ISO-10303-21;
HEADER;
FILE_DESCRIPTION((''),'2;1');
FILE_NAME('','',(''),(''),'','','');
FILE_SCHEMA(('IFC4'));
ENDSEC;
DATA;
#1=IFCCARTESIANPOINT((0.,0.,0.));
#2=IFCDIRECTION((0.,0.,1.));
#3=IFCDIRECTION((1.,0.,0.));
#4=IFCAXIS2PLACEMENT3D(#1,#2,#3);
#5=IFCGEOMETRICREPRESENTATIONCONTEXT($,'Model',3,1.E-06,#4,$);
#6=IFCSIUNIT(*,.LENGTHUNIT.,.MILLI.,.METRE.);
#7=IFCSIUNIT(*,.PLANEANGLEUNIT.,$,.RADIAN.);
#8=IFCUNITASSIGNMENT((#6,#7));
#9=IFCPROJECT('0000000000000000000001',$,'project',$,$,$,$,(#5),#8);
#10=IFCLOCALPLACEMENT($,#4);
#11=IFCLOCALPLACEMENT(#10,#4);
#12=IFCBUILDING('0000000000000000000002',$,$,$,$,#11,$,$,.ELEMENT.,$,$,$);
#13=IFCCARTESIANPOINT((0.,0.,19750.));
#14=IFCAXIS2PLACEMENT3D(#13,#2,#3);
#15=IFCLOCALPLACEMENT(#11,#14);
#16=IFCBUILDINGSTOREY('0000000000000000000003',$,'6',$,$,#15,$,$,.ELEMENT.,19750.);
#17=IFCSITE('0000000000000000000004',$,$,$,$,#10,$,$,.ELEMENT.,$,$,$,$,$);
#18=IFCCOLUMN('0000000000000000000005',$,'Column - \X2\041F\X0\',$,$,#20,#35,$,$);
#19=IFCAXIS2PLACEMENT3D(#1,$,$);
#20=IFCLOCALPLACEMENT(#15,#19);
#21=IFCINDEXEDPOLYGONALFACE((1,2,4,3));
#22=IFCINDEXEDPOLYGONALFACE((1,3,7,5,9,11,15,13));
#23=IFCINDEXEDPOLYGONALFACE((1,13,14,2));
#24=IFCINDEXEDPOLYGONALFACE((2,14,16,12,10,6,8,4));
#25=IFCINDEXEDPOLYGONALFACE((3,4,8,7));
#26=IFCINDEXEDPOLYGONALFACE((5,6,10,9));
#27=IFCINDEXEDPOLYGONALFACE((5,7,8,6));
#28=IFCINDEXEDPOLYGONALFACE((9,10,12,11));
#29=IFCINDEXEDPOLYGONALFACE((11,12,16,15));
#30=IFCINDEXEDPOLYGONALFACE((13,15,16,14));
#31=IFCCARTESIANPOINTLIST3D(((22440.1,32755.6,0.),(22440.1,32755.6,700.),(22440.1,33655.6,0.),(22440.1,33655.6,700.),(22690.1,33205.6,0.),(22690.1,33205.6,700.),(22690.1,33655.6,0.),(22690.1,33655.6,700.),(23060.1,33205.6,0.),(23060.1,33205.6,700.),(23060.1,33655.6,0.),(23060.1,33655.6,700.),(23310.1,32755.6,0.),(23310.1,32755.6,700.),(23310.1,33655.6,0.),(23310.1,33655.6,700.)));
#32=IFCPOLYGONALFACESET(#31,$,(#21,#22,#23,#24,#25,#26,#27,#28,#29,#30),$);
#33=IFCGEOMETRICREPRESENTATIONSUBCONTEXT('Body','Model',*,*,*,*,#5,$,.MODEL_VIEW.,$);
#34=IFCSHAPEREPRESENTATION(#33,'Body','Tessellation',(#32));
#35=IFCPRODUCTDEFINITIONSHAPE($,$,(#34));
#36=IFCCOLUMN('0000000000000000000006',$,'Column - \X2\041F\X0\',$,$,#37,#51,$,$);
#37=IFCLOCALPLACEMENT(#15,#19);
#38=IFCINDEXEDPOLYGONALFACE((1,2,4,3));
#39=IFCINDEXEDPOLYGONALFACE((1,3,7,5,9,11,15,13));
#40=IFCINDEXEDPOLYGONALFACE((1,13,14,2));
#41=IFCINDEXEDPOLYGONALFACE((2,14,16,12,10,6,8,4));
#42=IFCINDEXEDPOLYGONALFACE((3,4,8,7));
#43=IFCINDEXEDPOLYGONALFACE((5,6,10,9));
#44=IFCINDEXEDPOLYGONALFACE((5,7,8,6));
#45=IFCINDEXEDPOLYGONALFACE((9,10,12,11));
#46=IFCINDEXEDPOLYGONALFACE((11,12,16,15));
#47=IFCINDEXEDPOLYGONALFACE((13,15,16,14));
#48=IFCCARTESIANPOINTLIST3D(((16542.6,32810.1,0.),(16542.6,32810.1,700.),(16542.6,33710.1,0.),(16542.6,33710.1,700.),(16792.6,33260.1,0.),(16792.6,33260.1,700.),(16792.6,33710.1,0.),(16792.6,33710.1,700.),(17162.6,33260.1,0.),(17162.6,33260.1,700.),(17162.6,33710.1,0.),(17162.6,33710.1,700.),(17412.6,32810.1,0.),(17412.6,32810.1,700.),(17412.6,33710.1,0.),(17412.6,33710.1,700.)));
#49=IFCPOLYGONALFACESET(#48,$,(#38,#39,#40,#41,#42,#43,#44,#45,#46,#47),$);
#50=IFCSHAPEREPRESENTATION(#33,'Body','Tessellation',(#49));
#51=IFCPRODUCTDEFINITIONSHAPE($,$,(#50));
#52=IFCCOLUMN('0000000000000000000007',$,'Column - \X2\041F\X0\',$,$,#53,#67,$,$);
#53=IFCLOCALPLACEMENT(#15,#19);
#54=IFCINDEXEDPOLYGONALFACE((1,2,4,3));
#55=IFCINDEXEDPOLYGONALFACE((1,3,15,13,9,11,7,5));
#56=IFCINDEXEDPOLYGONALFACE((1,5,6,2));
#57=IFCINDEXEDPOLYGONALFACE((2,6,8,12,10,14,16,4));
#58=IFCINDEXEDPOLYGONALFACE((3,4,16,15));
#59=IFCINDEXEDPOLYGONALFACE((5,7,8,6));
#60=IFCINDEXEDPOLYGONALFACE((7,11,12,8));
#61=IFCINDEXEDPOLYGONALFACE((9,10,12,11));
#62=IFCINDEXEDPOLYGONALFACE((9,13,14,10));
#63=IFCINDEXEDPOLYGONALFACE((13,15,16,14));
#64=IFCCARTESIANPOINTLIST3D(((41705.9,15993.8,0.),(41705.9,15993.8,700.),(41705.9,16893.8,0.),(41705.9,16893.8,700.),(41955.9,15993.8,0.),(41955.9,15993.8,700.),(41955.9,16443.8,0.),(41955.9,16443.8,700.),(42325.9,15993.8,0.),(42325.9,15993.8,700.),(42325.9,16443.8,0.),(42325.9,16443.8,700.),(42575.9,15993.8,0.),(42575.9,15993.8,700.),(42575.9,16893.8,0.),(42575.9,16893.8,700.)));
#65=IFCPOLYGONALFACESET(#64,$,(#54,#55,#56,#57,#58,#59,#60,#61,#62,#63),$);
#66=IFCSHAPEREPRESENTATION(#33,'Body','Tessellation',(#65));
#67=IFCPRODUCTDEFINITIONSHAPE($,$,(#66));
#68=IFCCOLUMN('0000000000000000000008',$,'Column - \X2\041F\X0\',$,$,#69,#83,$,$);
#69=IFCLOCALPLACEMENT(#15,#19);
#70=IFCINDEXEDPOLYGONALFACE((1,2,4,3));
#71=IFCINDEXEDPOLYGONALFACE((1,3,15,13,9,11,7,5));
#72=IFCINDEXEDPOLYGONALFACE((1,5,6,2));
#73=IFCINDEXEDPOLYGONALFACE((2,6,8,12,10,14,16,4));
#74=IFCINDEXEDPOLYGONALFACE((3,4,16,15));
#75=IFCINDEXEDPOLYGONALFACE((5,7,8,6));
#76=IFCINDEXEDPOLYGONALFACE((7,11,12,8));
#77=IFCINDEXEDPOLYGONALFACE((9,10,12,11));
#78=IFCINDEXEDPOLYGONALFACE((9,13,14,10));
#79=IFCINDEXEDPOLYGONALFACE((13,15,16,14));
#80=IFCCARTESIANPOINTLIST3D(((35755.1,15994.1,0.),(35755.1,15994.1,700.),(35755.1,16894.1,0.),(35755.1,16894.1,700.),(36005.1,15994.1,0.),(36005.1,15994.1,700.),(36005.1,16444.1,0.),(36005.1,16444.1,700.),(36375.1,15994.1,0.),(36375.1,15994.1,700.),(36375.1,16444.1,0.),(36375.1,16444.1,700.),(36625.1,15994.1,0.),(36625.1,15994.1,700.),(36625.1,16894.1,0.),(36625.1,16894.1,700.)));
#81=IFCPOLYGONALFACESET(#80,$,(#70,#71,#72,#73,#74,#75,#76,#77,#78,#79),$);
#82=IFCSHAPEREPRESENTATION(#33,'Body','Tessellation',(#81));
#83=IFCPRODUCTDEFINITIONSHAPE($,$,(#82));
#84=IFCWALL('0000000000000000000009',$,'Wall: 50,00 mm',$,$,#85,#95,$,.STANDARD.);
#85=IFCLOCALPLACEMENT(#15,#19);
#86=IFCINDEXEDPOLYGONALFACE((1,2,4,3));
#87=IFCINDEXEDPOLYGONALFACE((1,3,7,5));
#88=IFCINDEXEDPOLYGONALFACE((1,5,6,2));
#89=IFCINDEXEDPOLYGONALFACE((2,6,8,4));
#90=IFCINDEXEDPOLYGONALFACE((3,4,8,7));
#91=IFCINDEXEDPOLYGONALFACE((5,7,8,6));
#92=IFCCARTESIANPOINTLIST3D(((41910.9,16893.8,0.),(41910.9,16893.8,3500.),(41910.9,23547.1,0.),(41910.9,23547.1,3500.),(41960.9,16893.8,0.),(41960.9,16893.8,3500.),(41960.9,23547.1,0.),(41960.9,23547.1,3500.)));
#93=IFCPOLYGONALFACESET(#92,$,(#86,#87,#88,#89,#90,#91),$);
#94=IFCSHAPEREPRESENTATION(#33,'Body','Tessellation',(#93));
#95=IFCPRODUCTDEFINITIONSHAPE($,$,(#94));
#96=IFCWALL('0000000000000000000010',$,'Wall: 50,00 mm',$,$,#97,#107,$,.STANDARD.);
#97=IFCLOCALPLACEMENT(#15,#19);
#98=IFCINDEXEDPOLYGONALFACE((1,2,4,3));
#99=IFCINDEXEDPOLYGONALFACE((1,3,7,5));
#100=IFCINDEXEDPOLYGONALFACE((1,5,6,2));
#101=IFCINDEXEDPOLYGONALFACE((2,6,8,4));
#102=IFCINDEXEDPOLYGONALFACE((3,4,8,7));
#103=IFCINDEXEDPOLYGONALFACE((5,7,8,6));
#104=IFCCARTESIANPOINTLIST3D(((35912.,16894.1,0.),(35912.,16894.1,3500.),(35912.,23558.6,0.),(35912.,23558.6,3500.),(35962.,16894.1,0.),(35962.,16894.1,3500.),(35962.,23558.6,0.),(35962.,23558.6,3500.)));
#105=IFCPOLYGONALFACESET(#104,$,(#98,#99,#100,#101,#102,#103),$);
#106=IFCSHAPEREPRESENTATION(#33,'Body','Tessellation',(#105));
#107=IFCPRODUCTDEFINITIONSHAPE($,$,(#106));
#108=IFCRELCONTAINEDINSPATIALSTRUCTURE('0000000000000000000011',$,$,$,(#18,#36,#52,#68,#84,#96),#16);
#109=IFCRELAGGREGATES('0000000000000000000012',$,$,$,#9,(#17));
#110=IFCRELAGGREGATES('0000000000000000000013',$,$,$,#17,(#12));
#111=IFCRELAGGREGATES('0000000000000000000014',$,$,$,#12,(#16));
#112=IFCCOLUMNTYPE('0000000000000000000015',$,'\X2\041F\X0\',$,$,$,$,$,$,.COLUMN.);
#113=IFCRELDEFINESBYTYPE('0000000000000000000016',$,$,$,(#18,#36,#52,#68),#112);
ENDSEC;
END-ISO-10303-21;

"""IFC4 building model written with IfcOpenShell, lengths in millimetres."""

from ifc_helpers import new_model, si_unit, frame, origin_with_axes, place, context, subcontext, project, spatial, line, indexed_curve, outline, extrude, source, transform, mapped, type_object, element, save


model = new_model("IFC4")

# Units and contexts
model_context = context("Model", 3, precision=1e-06, world=origin_with_axes())
body_context = subcontext(model_context, "Body", "Model", "MODEL_VIEW")
ifc_project = project(units=[si_unit("LENGTHUNIT", "METRE", prefix="MILLI"), si_unit("PLANEANGLEUNIT", "RADIAN")], contexts=[model_context])

# Site, building, storey
site_placement = place(None, origin_with_axes())
site = spatial("IfcSite", under=ifc_project, at=site_placement, CompositionType="ELEMENT")
building_placement = place(site_placement, origin_with_axes())
building = spatial("IfcBuilding", under=site, at=building_placement, CompositionType="ELEMENT")
storey_placement = place(building_placement, frame((0.0, 0.0, 19750.0), z_axis=(0.0, 0.0, 1.0), x_axis=(1.0, 0.0, 0.0)))
storey = spatial("IfcBuildingStorey", under=building, at=storey_placement, Name="6", CompositionType="ELEMENT", Elevation=19750.0)

# Columns
column_type_1 = type_object("IfcColumnType", Name="П", PredefinedType="COLUMN")
shared_shape_1 = source(origin_with_axes(), body_context, "Body", "SweptSolid", [
    extrude(outline(indexed_curve([(-450.0, -435.0), (450.0, -435.0), (450.0, -185.0), (0.0, -185.0), (0.0, 185.0), (450.0, 185.0), (450.0, 435.0), (-450.0, 435.0)], segments=[line(1, 2), line(2, 3), line(3, 4), line(4, 5), line(5, 6), line(6, 7), line(7, 8), line(8, 1)])), origin_with_axes(), (0.0, 0.0, 1.0), 700.0),
])
for number, where, z_axis, x_axis, name in (
    (1, (22875.1, 33205.6, 0.0), (0.0, 0.0, 1.0), (0.0, 1.0, 0.0), "Column - П"),
    (2, (16977.6, 33260.1, 0.0), (0.0, 0.0, 1.0), (0.0, 1.0, 0.0), "Column - П"),
    (3, (42140.9, 16443.8, 0.0), (0.0, 0.0, 1.0), (0.0, -1.0, 0.0), "Column - П"),
    (4, (36190.1, 16444.1, 0.0), (0.0, 0.0, 1.0), (0.0, -1.0, 0.0), "Column - П"),
):
    element("IfcColumn", number, at=place(storey_placement, frame(where, z_axis=z_axis, x_axis=x_axis)), inside=storey, type_object=column_type_1, Name=name, context=body_context, shape_type="MappedRepresentation", body=[
        mapped(shared_shape_1, transform((0.0, 0.0, 0.0), x_axis=(1.0, 0.0, 0.0), y_axis=(0.0, 1.0, 0.0), z_axis=(0.0, 0.0, 1.0), scale=1.0)),
    ])

# Walls
wall_1_placement = place(storey_placement, frame((41935.9, 23547.1, 0.0), z_axis=(0.0, 0.0, 1.0), x_axis=(0.0, -1.0, 0.0)))
element("IfcWall", 5, at=wall_1_placement, inside=storey, Name="Wall: 50,00 mm", PredefinedType="STANDARD", context=body_context, shape_type="SweptSolid", body=[
    extrude(outline(indexed_curve([(0.0, -25.0), (6653.3, -25.0), (6653.3, 25.0), (0.0, 25.0)], segments=[line(1, 2), line(2, 3), line(3, 4), line(4, 1)])), origin_with_axes(), (0.0, 0.0, 1.0), 3500.0),
])
wall_2_placement = place(storey_placement, frame((35937.0, 23558.6, 0.0), z_axis=(0.0, 0.0, 1.0), x_axis=(0.0, -1.0, 0.0)))
element("IfcWall", 6, at=wall_2_placement, inside=storey, Name="Wall: 50,00 mm", PredefinedType="STANDARD", context=body_context, shape_type="SweptSolid", body=[
    extrude(outline(indexed_curve([(0.0, -25.0), (6664.4, -25.0), (6664.4, 25.0), (0.0, 25.0)], segments=[line(1, 2), line(2, 3), line(3, 4), line(4, 1)])), origin_with_axes(), (0.0, 0.0, 1.0), 3500.0),
])

save(model, "model.ifc")
